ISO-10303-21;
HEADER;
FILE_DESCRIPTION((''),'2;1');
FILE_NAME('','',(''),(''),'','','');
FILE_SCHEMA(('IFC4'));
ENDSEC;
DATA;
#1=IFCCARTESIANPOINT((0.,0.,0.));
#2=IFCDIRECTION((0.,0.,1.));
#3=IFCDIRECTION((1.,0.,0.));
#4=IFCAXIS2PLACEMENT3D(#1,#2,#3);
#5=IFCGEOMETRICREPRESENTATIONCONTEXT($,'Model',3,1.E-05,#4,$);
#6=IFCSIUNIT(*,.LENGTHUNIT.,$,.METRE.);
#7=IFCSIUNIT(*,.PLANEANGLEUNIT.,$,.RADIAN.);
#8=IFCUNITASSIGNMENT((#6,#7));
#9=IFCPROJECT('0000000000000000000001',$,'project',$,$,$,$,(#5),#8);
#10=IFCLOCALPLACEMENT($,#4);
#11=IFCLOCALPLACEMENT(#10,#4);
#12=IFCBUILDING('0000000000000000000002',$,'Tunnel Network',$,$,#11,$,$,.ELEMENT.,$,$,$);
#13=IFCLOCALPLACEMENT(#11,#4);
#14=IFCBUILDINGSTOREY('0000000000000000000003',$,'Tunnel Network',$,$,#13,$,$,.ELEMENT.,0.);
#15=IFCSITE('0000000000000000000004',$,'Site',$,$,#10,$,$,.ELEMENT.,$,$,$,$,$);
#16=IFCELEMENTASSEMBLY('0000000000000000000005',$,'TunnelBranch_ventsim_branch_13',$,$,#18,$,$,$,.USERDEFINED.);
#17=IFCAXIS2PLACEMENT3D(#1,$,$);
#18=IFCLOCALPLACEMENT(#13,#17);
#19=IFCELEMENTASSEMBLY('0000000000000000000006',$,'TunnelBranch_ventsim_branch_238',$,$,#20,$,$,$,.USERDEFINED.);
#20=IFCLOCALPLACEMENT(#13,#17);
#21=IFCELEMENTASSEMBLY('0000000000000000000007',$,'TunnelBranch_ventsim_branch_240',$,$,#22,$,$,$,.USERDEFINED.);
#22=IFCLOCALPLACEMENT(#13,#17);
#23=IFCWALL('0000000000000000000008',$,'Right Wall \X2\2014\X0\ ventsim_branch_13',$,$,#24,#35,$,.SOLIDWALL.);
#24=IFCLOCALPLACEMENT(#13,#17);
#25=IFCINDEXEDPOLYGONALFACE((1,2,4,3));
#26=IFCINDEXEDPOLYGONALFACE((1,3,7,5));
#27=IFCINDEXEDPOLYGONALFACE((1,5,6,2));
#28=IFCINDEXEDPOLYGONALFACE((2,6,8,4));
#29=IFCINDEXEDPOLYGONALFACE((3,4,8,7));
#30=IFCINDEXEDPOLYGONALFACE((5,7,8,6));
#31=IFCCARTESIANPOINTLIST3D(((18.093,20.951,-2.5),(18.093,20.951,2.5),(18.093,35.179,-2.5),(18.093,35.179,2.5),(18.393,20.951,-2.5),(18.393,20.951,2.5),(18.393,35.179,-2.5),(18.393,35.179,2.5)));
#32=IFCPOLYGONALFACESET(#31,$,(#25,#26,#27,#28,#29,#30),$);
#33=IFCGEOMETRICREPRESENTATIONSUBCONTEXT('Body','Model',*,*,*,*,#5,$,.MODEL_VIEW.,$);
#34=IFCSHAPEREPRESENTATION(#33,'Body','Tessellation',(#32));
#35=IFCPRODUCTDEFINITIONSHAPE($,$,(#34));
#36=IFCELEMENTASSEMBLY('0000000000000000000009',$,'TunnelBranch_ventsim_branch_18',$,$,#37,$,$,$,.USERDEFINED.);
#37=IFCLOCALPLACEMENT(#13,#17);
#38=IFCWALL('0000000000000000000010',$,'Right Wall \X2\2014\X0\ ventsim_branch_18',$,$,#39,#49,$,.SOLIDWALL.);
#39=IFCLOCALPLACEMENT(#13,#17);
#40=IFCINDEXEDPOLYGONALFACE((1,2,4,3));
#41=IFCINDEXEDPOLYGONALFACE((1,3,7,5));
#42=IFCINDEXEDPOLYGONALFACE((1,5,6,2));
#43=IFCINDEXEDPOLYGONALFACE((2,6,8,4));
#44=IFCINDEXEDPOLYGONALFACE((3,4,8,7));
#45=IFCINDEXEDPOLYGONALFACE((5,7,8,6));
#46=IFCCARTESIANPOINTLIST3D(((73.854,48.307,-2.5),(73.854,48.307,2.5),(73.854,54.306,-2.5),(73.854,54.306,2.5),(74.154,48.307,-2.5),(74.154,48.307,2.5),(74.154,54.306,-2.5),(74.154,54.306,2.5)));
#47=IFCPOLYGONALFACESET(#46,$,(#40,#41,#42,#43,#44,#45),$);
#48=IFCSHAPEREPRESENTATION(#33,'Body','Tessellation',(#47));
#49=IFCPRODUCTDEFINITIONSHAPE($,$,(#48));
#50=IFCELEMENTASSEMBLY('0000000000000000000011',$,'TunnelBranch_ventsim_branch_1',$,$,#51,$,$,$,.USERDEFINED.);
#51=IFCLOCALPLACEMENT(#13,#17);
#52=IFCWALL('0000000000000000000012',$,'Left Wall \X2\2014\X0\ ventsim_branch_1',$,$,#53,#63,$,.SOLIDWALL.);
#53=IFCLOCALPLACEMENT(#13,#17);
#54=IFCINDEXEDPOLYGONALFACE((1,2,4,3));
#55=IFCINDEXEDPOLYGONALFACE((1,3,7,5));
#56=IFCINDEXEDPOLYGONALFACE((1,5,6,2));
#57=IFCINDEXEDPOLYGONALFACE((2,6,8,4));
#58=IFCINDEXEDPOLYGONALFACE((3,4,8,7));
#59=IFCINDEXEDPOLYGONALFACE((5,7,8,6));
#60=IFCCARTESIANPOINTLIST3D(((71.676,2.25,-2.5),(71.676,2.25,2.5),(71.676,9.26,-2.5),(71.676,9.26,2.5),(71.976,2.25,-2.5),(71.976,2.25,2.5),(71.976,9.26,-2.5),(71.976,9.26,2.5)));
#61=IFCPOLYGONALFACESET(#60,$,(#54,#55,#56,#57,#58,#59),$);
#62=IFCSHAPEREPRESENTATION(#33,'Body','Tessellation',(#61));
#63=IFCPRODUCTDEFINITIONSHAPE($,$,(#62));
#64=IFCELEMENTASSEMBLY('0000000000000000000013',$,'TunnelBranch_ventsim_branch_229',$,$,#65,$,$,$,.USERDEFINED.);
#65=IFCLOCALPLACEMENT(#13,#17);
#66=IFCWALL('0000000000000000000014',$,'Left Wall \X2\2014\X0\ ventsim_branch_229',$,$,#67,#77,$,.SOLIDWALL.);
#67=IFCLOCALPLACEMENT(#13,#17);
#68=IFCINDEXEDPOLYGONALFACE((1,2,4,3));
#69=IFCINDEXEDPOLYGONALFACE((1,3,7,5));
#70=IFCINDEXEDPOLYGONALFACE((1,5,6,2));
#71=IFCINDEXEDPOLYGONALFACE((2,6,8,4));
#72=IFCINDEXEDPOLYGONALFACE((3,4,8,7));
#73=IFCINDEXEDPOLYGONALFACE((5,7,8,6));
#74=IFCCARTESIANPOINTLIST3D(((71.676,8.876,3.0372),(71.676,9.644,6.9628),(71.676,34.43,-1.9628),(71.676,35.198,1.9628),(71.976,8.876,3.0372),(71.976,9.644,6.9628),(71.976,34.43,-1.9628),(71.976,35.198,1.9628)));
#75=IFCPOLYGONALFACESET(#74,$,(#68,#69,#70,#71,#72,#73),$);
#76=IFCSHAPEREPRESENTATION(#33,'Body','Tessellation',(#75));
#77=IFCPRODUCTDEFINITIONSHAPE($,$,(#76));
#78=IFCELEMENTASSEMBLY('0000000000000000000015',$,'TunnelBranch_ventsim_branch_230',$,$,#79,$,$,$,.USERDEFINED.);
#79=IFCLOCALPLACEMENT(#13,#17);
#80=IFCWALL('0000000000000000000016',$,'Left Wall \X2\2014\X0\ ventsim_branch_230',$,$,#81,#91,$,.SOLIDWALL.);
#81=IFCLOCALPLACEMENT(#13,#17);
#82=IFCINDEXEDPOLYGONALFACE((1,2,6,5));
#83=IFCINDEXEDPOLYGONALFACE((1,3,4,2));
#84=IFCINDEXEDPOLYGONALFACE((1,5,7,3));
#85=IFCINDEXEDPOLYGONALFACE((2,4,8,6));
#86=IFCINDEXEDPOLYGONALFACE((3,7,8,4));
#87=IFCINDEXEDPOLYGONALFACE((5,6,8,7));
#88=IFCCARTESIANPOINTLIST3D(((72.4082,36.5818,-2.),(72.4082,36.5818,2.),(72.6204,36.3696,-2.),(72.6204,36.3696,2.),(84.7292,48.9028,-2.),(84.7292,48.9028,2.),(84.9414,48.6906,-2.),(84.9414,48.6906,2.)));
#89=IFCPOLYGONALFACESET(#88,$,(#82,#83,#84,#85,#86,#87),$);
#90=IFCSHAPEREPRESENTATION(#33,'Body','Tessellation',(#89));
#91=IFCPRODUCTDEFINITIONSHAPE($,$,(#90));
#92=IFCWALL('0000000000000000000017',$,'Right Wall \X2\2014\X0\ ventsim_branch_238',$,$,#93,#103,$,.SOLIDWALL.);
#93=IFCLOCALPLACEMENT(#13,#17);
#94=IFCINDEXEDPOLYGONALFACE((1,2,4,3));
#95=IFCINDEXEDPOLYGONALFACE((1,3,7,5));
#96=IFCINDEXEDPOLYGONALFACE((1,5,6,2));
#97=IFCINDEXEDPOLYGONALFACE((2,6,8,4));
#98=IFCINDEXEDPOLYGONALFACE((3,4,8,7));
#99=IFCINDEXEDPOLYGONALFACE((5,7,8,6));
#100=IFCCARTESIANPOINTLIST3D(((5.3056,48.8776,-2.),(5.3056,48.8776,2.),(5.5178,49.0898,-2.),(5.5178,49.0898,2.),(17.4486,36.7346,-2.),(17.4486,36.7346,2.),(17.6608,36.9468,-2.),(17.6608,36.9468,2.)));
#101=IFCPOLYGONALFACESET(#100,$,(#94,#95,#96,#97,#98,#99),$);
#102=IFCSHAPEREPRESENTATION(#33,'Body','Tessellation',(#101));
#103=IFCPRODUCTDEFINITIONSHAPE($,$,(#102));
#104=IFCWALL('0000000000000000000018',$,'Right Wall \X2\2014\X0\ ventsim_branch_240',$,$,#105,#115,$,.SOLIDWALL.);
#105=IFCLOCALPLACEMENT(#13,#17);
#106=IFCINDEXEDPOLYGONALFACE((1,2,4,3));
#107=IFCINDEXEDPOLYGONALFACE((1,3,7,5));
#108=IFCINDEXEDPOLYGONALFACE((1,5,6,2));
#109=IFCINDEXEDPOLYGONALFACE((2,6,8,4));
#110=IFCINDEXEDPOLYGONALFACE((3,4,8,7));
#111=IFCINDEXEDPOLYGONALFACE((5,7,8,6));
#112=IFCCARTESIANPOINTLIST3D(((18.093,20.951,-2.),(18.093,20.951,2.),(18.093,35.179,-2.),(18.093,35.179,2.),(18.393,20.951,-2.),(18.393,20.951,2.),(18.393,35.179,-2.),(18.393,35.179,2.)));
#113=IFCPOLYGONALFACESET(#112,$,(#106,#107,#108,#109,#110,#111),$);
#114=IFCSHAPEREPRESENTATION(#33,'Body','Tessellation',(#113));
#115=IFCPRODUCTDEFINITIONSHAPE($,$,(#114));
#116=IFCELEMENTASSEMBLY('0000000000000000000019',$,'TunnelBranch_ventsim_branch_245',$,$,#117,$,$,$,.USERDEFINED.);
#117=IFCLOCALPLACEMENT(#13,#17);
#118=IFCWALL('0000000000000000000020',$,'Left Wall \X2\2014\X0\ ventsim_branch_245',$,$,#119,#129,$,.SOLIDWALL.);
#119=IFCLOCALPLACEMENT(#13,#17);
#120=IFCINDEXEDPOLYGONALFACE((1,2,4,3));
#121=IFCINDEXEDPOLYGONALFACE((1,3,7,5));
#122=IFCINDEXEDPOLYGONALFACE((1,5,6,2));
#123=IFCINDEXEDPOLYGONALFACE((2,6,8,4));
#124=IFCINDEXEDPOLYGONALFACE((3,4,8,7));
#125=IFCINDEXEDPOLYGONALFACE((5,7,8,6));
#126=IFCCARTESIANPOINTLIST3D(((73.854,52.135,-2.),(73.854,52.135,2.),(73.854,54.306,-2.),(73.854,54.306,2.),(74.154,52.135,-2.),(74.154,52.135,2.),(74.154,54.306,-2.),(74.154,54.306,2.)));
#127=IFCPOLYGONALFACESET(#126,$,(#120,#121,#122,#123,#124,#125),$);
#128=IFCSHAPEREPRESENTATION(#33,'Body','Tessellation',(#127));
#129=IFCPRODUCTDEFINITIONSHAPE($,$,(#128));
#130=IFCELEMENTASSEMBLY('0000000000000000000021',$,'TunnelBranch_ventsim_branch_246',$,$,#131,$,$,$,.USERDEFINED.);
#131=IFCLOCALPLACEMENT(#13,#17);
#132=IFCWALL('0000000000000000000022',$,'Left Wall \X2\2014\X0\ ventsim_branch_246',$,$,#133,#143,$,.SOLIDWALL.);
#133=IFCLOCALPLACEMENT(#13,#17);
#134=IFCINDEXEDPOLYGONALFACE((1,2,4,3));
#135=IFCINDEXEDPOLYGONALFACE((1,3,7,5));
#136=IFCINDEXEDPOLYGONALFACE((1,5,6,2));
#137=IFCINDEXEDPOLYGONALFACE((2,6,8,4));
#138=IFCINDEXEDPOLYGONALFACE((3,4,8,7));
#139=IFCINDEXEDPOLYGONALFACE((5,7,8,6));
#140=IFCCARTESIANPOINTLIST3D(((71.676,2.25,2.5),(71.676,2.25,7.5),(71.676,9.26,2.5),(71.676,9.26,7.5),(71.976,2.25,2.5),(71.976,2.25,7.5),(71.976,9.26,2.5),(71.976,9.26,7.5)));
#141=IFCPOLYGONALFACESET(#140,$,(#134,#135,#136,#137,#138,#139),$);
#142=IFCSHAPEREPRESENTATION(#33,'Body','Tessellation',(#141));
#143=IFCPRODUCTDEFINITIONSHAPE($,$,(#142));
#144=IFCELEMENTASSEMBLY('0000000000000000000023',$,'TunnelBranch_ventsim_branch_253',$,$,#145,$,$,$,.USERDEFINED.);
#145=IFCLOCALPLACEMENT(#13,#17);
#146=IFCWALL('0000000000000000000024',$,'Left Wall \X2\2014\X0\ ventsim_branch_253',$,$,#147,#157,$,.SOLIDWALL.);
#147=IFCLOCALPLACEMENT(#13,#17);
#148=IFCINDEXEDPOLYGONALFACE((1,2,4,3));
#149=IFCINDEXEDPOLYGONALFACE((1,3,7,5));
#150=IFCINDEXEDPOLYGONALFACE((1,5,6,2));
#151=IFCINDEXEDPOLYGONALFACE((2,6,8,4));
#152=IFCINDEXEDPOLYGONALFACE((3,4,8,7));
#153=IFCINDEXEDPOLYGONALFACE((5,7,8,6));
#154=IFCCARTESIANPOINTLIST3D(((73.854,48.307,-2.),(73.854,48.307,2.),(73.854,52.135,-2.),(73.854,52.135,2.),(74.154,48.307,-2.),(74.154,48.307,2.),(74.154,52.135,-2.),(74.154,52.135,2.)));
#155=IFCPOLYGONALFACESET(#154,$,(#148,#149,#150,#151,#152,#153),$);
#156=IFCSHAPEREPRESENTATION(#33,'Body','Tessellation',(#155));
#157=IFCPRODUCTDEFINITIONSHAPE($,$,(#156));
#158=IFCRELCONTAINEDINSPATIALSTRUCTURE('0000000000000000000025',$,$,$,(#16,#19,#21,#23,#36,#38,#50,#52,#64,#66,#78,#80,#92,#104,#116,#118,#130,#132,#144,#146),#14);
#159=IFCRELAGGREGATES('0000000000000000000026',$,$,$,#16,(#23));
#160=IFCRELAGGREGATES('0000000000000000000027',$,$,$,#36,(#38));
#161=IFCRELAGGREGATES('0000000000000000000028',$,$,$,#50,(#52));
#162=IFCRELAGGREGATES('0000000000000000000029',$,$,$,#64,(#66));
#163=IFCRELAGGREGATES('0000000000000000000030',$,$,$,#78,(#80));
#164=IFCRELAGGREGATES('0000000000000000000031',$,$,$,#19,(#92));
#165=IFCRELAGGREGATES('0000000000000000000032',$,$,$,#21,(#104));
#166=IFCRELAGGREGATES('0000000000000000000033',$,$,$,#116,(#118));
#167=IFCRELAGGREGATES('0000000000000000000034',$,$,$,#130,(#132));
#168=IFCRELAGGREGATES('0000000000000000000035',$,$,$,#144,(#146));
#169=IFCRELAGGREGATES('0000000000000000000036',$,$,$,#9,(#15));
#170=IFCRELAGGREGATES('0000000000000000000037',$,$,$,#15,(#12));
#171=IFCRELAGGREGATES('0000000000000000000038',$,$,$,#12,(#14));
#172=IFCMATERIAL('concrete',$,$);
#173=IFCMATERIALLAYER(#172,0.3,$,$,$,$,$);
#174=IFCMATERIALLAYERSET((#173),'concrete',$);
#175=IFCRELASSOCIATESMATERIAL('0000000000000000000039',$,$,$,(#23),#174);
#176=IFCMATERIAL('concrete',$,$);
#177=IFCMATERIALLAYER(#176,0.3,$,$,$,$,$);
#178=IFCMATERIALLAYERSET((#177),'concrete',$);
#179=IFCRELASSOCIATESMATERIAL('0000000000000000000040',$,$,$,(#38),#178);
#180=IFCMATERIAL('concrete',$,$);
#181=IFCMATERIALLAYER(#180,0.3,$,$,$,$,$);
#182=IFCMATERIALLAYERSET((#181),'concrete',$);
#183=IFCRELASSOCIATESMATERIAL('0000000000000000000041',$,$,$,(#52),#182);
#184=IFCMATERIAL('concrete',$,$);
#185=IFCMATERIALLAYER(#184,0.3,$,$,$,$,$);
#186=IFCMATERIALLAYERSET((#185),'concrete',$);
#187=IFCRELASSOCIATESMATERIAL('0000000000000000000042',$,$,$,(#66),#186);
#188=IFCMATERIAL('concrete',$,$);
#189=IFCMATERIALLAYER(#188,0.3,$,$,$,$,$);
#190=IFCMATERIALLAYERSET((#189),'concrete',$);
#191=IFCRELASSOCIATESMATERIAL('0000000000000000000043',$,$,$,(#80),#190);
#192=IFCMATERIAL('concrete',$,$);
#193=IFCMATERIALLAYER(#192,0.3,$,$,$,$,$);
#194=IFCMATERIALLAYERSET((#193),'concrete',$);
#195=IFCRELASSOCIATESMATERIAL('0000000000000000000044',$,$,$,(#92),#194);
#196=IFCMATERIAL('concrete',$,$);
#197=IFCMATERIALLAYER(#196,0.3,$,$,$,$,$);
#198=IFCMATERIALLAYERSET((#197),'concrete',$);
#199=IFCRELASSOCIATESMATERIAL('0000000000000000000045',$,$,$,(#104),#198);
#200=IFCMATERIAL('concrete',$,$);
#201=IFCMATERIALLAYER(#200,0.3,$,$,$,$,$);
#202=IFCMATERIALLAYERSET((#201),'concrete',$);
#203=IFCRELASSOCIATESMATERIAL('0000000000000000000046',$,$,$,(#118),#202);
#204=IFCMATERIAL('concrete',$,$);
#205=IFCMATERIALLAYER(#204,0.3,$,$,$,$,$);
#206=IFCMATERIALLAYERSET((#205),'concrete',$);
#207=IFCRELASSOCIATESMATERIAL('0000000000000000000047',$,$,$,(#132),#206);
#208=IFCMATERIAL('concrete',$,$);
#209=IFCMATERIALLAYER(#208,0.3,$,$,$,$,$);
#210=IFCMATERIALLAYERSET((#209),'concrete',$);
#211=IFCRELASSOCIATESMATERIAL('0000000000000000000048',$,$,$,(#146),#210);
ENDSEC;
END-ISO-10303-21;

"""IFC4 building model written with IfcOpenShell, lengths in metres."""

from ifc_helpers import new_model, si_unit, frame, origin_with_axes, origin_2d_with_axis, place, context, subcontext, project, spatial, rectangle, extrude, material, layer, layer_set, layer_usage, element, aggregate, save


model = new_model("IFC4")

# Units and contexts
model_context = context("Model", 3, precision=1e-05, world=origin_with_axes())
body_context = subcontext(model_context, "Body", "Model", "MODEL_VIEW")
ifc_project = project(units=[si_unit("LENGTHUNIT", "METRE"), si_unit("PLANEANGLEUNIT", "RADIAN")], contexts=[model_context])

# Site, building, storey
site_placement = place(None, origin_with_axes())
site = spatial("IfcSite", under=ifc_project, at=site_placement, Name="Site", CompositionType="ELEMENT")
building_placement = place(site_placement, origin_with_axes())
building = spatial("IfcBuilding", under=site, at=building_placement, Name="Tunnel Network", CompositionType="ELEMENT")
storey_placement = place(building_placement, origin_with_axes())
storey = spatial("IfcBuildingStorey", under=building, at=storey_placement, Name="Tunnel Network", CompositionType="ELEMENT", Elevation=0.0)

# Element assemblies
assembly_1_placement = place(storey_placement, frame((13.543, 20.951, 0.0), z_axis=(0.0, 1.0, 0.0), x_axis=(1.0, 0.0, 0.0)))
assembly_1 = element("IfcElementAssembly", 1, at=assembly_1_placement, inside=storey, Name="TunnelBranch_ventsim_branch_13", PredefinedType="USERDEFINED")
assembly_2_placement = place(storey_placement, frame((14.2313, 33.5173, 0.0), z_axis=(-0.707107, 0.707107, 0.0), x_axis=(0.707107, 0.707107, 0.0)))
assembly_2 = element("IfcElementAssembly", 2, at=assembly_2_placement, inside=storey, Name="TunnelBranch_ventsim_branch_238", PredefinedType="USERDEFINED")
assembly_3_placement = place(storey_placement, frame((13.543, 20.951, 0.0), z_axis=(0.0, 1.0, 0.0), x_axis=(1.0, 0.0, 0.0)))
assembly_3 = element("IfcElementAssembly", 3, at=assembly_3_placement, inside=storey, Name="TunnelBranch_ventsim_branch_240", PredefinedType="USERDEFINED")

# Wall
ifc_material_1 = material(Name="concrete")
ifc_layer_1 = layer(ifc_material_1, 0.3)
ifc_layer_set_1 = layer_set([ifc_layer_1], Name="concrete")
ifc_layer_usage_1 = layer_usage(ifc_layer_set_1, "AXIS2", "POSITIVE", 0.0)
wall_1_placement = place(storey_placement, frame((18.243, 20.951, 0.0), z_axis=(0.0, 1.0, 0.0), x_axis=(1.0, 0.0, 0.0)))
wall_1 = element("IfcWall", 4, at=wall_1_placement, inside=storey, material=ifc_layer_usage_1, Name="Right Wall — ventsim_branch_13", PredefinedType="SOLIDWALL", context=body_context, shape_type="SweptSolid", body=[
    extrude(rectangle(XDim=0.3, YDim=5.0, at=origin_2d_with_axis()), origin_with_axes(), (0.0, 0.0, 1.0), 14.228),
])
aggregate(assembly_1, [wall_1])

# Element assemblies, walls
assembly_4_placement = place(storey_placement, frame((78.704, 54.306, 0.0), z_axis=(0.0, -1.0, 0.0), x_axis=(-1.0, 0.0, 0.0)))
assembly_4 = element("IfcElementAssembly", 5, at=assembly_4_placement, inside=storey, Name="TunnelBranch_ventsim_branch_18", PredefinedType="USERDEFINED")
ifc_material_2 = material(Name="concrete")
ifc_layer_2 = layer(ifc_material_2, 0.3)
ifc_layer_set_2 = layer_set([ifc_layer_2], Name="concrete")
ifc_layer_usage_2 = layer_usage(ifc_layer_set_2, "AXIS2", "POSITIVE", 0.0)
wall_2_placement = place(storey_placement, frame((74.004, 54.306, 0.0), z_axis=(0.0, -1.0, 0.0), x_axis=(-1.0, 0.0, 0.0)))
wall_2 = element("IfcWall", 6, at=wall_2_placement, inside=storey, material=ifc_layer_usage_2, Name="Right Wall — ventsim_branch_18", PredefinedType="SOLIDWALL", context=body_context, shape_type="SweptSolid", body=[
    extrude(rectangle(XDim=0.3, YDim=5.0, at=origin_2d_with_axis()), origin_with_axes(), (0.0, 0.0, 1.0), 5.999),
])
aggregate(assembly_4, [wall_2])
assembly_5_placement = place(storey_placement, frame((71.826, 2.25, 0.0), z_axis=(0.0, 1.0, 0.0), x_axis=(1.0, 0.0, 0.0)))
assembly_5 = element("IfcElementAssembly", 7, at=assembly_5_placement, inside=storey, Name="TunnelBranch_ventsim_branch_1", PredefinedType="USERDEFINED")
ifc_material_3 = material(Name="concrete")
ifc_layer_3 = layer(ifc_material_3, 0.3)
ifc_layer_set_3 = layer_set([ifc_layer_3], Name="concrete")
ifc_layer_usage_3 = layer_usage(ifc_layer_set_3, "AXIS2", "POSITIVE", 0.0)
wall_3_placement = place(storey_placement, frame((71.826, 2.25, 0.0), z_axis=(0.0, 1.0, 0.0), x_axis=(1.0, 0.0, 0.0)))
wall_3 = element("IfcWall", 8, at=wall_3_placement, inside=storey, material=ifc_layer_usage_3, Name="Left Wall — ventsim_branch_1", PredefinedType="SOLIDWALL", context=body_context, shape_type="SweptSolid", body=[
    extrude(rectangle(XDim=0.3, YDim=5.0, at=origin_2d_with_axis()), origin_with_axes(), (0.0, 0.0, 1.0), 7.01),
])
aggregate(assembly_5, [wall_3])
assembly_6_placement = place(storey_placement, frame((71.826, 9.26, 5.0), z_axis=(0.0, 0.98139, -0.192023), x_axis=(1.0, 0.0, 0.0)))
assembly_6 = element("IfcElementAssembly", 9, at=assembly_6_placement, inside=storey, Name="TunnelBranch_ventsim_branch_229", PredefinedType="USERDEFINED")
ifc_material_4 = material(Name="concrete")
ifc_layer_4 = layer(ifc_material_4, 0.3)
ifc_layer_set_4 = layer_set([ifc_layer_4], Name="concrete")
ifc_layer_usage_4 = layer_usage(ifc_layer_set_4, "AXIS2", "POSITIVE", 0.0)
wall_4_placement = place(storey_placement, frame((71.826, 9.26, 5.0), z_axis=(0.0, 0.98139, -0.192023), x_axis=(1.0, 0.0, 0.0)))
wall_4 = element("IfcWall", 10, at=wall_4_placement, inside=storey, material=ifc_layer_usage_4, Name="Left Wall — ventsim_branch_229", PredefinedType="SOLIDWALL", context=body_context, shape_type="SweptSolid", body=[
    extrude(rectangle(XDim=0.3, YDim=4.0, at=origin_2d_with_axis()), origin_with_axes(), (0.0, 0.0, 1.0), 26.0386),
])
aggregate(assembly_6, [wall_4])
assembly_7_placement = place(storey_placement, frame((72.5143, 36.4757, 0.0), z_axis=(0.707107, 0.707107, 0.0), x_axis=(0.707107, -0.707107, 0.0)))
assembly_7 = element("IfcElementAssembly", 11, at=assembly_7_placement, inside=storey, Name="TunnelBranch_ventsim_branch_230", PredefinedType="USERDEFINED")
ifc_material_5 = material(Name="concrete")
ifc_layer_5 = layer(ifc_material_5, 0.3)
ifc_layer_set_5 = layer_set([ifc_layer_5], Name="concrete")
ifc_layer_usage_5 = layer_usage(ifc_layer_set_5, "AXIS2", "POSITIVE", 0.0)
wall_5_placement = place(storey_placement, frame((72.5143, 36.4757, 0.0), z_axis=(0.707107, 0.707107, 0.0), x_axis=(0.707107, -0.707107, 0.0)))
wall_5 = element("IfcWall", 12, at=wall_5_placement, inside=storey, material=ifc_layer_usage_5, Name="Left Wall — ventsim_branch_230", PredefinedType="SOLIDWALL", context=body_context, shape_type="SweptSolid", body=[
    extrude(rectangle(XDim=0.3, YDim=4.0, at=origin_2d_with_axis()), origin_with_axes(), (0.0, 0.0, 1.0), 17.4245),
])
aggregate(assembly_7, [wall_5])

# Walls
ifc_material_6 = material(Name="concrete")
ifc_layer_6 = layer(ifc_material_6, 0.3)
ifc_layer_set_6 = layer_set([ifc_layer_6], Name="concrete")
ifc_layer_usage_6 = layer_usage(ifc_layer_set_6, "AXIS2", "POSITIVE", 0.0)
wall_6_placement = place(storey_placement, frame((17.5547, 36.8407, 0.0), z_axis=(-0.707107, 0.707107, 0.0), x_axis=(0.707107, 0.707107, 0.0)))
wall_6 = element("IfcWall", 13, at=wall_6_placement, inside=storey, material=ifc_layer_usage_6, Name="Right Wall — ventsim_branch_238", PredefinedType="SOLIDWALL", context=body_context, shape_type="SweptSolid", body=[
    extrude(rectangle(XDim=0.3, YDim=4.0, at=origin_2d_with_axis()), origin_with_axes(), (0.0, 0.0, 1.0), 17.1728),
])
aggregate(assembly_2, [wall_6])
ifc_material_7 = material(Name="concrete")
ifc_layer_7 = layer(ifc_material_7, 0.3)
ifc_layer_set_7 = layer_set([ifc_layer_7], Name="concrete")
ifc_layer_usage_7 = layer_usage(ifc_layer_set_7, "AXIS2", "POSITIVE", 0.0)
wall_7_placement = place(storey_placement, frame((18.243, 20.951, 0.0), z_axis=(0.0, 1.0, 0.0), x_axis=(1.0, 0.0, 0.0)))
wall_7 = element("IfcWall", 14, at=wall_7_placement, inside=storey, material=ifc_layer_usage_7, Name="Right Wall — ventsim_branch_240", PredefinedType="SOLIDWALL", context=body_context, shape_type="SweptSolid", body=[
    extrude(rectangle(XDim=0.3, YDim=4.0, at=origin_2d_with_axis()), origin_with_axes(), (0.0, 0.0, 1.0), 14.228),
])
aggregate(assembly_3, [wall_7])

# Element assemblies, walls
assembly_8_placement = place(storey_placement, frame((74.004, 52.135, 0.0), z_axis=(0.0, 1.0, 0.0), x_axis=(1.0, 0.0, 0.0)))
assembly_8 = element("IfcElementAssembly", 15, at=assembly_8_placement, inside=storey, Name="TunnelBranch_ventsim_branch_245", PredefinedType="USERDEFINED")
ifc_material_8 = material(Name="concrete")
ifc_layer_8 = layer(ifc_material_8, 0.3)
ifc_layer_set_8 = layer_set([ifc_layer_8], Name="concrete")
ifc_layer_usage_8 = layer_usage(ifc_layer_set_8, "AXIS2", "POSITIVE", 0.0)
wall_8_placement = place(storey_placement, frame((74.004, 52.135, 0.0), z_axis=(0.0, 1.0, 0.0), x_axis=(1.0, 0.0, 0.0)))
wall_8 = element("IfcWall", 16, at=wall_8_placement, inside=storey, material=ifc_layer_usage_8, Name="Left Wall — ventsim_branch_245", PredefinedType="SOLIDWALL", context=body_context, shape_type="SweptSolid", body=[
    extrude(rectangle(XDim=0.3, YDim=4.0, at=origin_2d_with_axis()), origin_with_axes(), (0.0, 0.0, 1.0), 2.171),
])
aggregate(assembly_8, [wall_8])
assembly_9_placement = place(storey_placement, frame((71.826, 2.25, 5.0), z_axis=(0.0, 1.0, 0.0), x_axis=(1.0, 0.0, 0.0)))
assembly_9 = element("IfcElementAssembly", 17, at=assembly_9_placement, inside=storey, Name="TunnelBranch_ventsim_branch_246", PredefinedType="USERDEFINED")
ifc_material_9 = material(Name="concrete")
ifc_layer_9 = layer(ifc_material_9, 0.3)
ifc_layer_set_9 = layer_set([ifc_layer_9], Name="concrete")
ifc_layer_usage_9 = layer_usage(ifc_layer_set_9, "AXIS2", "POSITIVE", 0.0)
wall_9_placement = place(storey_placement, frame((71.826, 2.25, 5.0), z_axis=(0.0, 1.0, 0.0), x_axis=(1.0, 0.0, 0.0)))
wall_9 = element("IfcWall", 18, at=wall_9_placement, inside=storey, material=ifc_layer_usage_9, Name="Left Wall — ventsim_branch_246", PredefinedType="SOLIDWALL", context=body_context, shape_type="SweptSolid", body=[
    extrude(rectangle(XDim=0.3, YDim=5.0, at=origin_2d_with_axis()), origin_with_axes(), (0.0, 0.0, 1.0), 7.01),
])
aggregate(assembly_9, [wall_9])
assembly_10_placement = place(storey_placement, frame((74.004, 48.307, 0.0), z_axis=(0.0, 1.0, 0.0), x_axis=(1.0, 0.0, 0.0)))
assembly_10 = element("IfcElementAssembly", 19, at=assembly_10_placement, inside=storey, Name="TunnelBranch_ventsim_branch_253", PredefinedType="USERDEFINED")
ifc_material_10 = material(Name="concrete")
ifc_layer_10 = layer(ifc_material_10, 0.3)
ifc_layer_set_10 = layer_set([ifc_layer_10], Name="concrete")
ifc_layer_usage_10 = layer_usage(ifc_layer_set_10, "AXIS2", "POSITIVE", 0.0)
wall_10_placement = place(storey_placement, frame((74.004, 48.307, 0.0), z_axis=(0.0, 1.0, 0.0), x_axis=(1.0, 0.0, 0.0)))
wall_10 = element("IfcWall", 20, at=wall_10_placement, inside=storey, material=ifc_layer_usage_10, Name="Left Wall — ventsim_branch_253", PredefinedType="SOLIDWALL", context=body_context, shape_type="SweptSolid", body=[
    extrude(rectangle(XDim=0.3, YDim=4.0, at=origin_2d_with_axis()), origin_with_axes(), (0.0, 0.0, 1.0), 3.828),
])
aggregate(assembly_10, [wall_10])

save(model, "model.ifc")
